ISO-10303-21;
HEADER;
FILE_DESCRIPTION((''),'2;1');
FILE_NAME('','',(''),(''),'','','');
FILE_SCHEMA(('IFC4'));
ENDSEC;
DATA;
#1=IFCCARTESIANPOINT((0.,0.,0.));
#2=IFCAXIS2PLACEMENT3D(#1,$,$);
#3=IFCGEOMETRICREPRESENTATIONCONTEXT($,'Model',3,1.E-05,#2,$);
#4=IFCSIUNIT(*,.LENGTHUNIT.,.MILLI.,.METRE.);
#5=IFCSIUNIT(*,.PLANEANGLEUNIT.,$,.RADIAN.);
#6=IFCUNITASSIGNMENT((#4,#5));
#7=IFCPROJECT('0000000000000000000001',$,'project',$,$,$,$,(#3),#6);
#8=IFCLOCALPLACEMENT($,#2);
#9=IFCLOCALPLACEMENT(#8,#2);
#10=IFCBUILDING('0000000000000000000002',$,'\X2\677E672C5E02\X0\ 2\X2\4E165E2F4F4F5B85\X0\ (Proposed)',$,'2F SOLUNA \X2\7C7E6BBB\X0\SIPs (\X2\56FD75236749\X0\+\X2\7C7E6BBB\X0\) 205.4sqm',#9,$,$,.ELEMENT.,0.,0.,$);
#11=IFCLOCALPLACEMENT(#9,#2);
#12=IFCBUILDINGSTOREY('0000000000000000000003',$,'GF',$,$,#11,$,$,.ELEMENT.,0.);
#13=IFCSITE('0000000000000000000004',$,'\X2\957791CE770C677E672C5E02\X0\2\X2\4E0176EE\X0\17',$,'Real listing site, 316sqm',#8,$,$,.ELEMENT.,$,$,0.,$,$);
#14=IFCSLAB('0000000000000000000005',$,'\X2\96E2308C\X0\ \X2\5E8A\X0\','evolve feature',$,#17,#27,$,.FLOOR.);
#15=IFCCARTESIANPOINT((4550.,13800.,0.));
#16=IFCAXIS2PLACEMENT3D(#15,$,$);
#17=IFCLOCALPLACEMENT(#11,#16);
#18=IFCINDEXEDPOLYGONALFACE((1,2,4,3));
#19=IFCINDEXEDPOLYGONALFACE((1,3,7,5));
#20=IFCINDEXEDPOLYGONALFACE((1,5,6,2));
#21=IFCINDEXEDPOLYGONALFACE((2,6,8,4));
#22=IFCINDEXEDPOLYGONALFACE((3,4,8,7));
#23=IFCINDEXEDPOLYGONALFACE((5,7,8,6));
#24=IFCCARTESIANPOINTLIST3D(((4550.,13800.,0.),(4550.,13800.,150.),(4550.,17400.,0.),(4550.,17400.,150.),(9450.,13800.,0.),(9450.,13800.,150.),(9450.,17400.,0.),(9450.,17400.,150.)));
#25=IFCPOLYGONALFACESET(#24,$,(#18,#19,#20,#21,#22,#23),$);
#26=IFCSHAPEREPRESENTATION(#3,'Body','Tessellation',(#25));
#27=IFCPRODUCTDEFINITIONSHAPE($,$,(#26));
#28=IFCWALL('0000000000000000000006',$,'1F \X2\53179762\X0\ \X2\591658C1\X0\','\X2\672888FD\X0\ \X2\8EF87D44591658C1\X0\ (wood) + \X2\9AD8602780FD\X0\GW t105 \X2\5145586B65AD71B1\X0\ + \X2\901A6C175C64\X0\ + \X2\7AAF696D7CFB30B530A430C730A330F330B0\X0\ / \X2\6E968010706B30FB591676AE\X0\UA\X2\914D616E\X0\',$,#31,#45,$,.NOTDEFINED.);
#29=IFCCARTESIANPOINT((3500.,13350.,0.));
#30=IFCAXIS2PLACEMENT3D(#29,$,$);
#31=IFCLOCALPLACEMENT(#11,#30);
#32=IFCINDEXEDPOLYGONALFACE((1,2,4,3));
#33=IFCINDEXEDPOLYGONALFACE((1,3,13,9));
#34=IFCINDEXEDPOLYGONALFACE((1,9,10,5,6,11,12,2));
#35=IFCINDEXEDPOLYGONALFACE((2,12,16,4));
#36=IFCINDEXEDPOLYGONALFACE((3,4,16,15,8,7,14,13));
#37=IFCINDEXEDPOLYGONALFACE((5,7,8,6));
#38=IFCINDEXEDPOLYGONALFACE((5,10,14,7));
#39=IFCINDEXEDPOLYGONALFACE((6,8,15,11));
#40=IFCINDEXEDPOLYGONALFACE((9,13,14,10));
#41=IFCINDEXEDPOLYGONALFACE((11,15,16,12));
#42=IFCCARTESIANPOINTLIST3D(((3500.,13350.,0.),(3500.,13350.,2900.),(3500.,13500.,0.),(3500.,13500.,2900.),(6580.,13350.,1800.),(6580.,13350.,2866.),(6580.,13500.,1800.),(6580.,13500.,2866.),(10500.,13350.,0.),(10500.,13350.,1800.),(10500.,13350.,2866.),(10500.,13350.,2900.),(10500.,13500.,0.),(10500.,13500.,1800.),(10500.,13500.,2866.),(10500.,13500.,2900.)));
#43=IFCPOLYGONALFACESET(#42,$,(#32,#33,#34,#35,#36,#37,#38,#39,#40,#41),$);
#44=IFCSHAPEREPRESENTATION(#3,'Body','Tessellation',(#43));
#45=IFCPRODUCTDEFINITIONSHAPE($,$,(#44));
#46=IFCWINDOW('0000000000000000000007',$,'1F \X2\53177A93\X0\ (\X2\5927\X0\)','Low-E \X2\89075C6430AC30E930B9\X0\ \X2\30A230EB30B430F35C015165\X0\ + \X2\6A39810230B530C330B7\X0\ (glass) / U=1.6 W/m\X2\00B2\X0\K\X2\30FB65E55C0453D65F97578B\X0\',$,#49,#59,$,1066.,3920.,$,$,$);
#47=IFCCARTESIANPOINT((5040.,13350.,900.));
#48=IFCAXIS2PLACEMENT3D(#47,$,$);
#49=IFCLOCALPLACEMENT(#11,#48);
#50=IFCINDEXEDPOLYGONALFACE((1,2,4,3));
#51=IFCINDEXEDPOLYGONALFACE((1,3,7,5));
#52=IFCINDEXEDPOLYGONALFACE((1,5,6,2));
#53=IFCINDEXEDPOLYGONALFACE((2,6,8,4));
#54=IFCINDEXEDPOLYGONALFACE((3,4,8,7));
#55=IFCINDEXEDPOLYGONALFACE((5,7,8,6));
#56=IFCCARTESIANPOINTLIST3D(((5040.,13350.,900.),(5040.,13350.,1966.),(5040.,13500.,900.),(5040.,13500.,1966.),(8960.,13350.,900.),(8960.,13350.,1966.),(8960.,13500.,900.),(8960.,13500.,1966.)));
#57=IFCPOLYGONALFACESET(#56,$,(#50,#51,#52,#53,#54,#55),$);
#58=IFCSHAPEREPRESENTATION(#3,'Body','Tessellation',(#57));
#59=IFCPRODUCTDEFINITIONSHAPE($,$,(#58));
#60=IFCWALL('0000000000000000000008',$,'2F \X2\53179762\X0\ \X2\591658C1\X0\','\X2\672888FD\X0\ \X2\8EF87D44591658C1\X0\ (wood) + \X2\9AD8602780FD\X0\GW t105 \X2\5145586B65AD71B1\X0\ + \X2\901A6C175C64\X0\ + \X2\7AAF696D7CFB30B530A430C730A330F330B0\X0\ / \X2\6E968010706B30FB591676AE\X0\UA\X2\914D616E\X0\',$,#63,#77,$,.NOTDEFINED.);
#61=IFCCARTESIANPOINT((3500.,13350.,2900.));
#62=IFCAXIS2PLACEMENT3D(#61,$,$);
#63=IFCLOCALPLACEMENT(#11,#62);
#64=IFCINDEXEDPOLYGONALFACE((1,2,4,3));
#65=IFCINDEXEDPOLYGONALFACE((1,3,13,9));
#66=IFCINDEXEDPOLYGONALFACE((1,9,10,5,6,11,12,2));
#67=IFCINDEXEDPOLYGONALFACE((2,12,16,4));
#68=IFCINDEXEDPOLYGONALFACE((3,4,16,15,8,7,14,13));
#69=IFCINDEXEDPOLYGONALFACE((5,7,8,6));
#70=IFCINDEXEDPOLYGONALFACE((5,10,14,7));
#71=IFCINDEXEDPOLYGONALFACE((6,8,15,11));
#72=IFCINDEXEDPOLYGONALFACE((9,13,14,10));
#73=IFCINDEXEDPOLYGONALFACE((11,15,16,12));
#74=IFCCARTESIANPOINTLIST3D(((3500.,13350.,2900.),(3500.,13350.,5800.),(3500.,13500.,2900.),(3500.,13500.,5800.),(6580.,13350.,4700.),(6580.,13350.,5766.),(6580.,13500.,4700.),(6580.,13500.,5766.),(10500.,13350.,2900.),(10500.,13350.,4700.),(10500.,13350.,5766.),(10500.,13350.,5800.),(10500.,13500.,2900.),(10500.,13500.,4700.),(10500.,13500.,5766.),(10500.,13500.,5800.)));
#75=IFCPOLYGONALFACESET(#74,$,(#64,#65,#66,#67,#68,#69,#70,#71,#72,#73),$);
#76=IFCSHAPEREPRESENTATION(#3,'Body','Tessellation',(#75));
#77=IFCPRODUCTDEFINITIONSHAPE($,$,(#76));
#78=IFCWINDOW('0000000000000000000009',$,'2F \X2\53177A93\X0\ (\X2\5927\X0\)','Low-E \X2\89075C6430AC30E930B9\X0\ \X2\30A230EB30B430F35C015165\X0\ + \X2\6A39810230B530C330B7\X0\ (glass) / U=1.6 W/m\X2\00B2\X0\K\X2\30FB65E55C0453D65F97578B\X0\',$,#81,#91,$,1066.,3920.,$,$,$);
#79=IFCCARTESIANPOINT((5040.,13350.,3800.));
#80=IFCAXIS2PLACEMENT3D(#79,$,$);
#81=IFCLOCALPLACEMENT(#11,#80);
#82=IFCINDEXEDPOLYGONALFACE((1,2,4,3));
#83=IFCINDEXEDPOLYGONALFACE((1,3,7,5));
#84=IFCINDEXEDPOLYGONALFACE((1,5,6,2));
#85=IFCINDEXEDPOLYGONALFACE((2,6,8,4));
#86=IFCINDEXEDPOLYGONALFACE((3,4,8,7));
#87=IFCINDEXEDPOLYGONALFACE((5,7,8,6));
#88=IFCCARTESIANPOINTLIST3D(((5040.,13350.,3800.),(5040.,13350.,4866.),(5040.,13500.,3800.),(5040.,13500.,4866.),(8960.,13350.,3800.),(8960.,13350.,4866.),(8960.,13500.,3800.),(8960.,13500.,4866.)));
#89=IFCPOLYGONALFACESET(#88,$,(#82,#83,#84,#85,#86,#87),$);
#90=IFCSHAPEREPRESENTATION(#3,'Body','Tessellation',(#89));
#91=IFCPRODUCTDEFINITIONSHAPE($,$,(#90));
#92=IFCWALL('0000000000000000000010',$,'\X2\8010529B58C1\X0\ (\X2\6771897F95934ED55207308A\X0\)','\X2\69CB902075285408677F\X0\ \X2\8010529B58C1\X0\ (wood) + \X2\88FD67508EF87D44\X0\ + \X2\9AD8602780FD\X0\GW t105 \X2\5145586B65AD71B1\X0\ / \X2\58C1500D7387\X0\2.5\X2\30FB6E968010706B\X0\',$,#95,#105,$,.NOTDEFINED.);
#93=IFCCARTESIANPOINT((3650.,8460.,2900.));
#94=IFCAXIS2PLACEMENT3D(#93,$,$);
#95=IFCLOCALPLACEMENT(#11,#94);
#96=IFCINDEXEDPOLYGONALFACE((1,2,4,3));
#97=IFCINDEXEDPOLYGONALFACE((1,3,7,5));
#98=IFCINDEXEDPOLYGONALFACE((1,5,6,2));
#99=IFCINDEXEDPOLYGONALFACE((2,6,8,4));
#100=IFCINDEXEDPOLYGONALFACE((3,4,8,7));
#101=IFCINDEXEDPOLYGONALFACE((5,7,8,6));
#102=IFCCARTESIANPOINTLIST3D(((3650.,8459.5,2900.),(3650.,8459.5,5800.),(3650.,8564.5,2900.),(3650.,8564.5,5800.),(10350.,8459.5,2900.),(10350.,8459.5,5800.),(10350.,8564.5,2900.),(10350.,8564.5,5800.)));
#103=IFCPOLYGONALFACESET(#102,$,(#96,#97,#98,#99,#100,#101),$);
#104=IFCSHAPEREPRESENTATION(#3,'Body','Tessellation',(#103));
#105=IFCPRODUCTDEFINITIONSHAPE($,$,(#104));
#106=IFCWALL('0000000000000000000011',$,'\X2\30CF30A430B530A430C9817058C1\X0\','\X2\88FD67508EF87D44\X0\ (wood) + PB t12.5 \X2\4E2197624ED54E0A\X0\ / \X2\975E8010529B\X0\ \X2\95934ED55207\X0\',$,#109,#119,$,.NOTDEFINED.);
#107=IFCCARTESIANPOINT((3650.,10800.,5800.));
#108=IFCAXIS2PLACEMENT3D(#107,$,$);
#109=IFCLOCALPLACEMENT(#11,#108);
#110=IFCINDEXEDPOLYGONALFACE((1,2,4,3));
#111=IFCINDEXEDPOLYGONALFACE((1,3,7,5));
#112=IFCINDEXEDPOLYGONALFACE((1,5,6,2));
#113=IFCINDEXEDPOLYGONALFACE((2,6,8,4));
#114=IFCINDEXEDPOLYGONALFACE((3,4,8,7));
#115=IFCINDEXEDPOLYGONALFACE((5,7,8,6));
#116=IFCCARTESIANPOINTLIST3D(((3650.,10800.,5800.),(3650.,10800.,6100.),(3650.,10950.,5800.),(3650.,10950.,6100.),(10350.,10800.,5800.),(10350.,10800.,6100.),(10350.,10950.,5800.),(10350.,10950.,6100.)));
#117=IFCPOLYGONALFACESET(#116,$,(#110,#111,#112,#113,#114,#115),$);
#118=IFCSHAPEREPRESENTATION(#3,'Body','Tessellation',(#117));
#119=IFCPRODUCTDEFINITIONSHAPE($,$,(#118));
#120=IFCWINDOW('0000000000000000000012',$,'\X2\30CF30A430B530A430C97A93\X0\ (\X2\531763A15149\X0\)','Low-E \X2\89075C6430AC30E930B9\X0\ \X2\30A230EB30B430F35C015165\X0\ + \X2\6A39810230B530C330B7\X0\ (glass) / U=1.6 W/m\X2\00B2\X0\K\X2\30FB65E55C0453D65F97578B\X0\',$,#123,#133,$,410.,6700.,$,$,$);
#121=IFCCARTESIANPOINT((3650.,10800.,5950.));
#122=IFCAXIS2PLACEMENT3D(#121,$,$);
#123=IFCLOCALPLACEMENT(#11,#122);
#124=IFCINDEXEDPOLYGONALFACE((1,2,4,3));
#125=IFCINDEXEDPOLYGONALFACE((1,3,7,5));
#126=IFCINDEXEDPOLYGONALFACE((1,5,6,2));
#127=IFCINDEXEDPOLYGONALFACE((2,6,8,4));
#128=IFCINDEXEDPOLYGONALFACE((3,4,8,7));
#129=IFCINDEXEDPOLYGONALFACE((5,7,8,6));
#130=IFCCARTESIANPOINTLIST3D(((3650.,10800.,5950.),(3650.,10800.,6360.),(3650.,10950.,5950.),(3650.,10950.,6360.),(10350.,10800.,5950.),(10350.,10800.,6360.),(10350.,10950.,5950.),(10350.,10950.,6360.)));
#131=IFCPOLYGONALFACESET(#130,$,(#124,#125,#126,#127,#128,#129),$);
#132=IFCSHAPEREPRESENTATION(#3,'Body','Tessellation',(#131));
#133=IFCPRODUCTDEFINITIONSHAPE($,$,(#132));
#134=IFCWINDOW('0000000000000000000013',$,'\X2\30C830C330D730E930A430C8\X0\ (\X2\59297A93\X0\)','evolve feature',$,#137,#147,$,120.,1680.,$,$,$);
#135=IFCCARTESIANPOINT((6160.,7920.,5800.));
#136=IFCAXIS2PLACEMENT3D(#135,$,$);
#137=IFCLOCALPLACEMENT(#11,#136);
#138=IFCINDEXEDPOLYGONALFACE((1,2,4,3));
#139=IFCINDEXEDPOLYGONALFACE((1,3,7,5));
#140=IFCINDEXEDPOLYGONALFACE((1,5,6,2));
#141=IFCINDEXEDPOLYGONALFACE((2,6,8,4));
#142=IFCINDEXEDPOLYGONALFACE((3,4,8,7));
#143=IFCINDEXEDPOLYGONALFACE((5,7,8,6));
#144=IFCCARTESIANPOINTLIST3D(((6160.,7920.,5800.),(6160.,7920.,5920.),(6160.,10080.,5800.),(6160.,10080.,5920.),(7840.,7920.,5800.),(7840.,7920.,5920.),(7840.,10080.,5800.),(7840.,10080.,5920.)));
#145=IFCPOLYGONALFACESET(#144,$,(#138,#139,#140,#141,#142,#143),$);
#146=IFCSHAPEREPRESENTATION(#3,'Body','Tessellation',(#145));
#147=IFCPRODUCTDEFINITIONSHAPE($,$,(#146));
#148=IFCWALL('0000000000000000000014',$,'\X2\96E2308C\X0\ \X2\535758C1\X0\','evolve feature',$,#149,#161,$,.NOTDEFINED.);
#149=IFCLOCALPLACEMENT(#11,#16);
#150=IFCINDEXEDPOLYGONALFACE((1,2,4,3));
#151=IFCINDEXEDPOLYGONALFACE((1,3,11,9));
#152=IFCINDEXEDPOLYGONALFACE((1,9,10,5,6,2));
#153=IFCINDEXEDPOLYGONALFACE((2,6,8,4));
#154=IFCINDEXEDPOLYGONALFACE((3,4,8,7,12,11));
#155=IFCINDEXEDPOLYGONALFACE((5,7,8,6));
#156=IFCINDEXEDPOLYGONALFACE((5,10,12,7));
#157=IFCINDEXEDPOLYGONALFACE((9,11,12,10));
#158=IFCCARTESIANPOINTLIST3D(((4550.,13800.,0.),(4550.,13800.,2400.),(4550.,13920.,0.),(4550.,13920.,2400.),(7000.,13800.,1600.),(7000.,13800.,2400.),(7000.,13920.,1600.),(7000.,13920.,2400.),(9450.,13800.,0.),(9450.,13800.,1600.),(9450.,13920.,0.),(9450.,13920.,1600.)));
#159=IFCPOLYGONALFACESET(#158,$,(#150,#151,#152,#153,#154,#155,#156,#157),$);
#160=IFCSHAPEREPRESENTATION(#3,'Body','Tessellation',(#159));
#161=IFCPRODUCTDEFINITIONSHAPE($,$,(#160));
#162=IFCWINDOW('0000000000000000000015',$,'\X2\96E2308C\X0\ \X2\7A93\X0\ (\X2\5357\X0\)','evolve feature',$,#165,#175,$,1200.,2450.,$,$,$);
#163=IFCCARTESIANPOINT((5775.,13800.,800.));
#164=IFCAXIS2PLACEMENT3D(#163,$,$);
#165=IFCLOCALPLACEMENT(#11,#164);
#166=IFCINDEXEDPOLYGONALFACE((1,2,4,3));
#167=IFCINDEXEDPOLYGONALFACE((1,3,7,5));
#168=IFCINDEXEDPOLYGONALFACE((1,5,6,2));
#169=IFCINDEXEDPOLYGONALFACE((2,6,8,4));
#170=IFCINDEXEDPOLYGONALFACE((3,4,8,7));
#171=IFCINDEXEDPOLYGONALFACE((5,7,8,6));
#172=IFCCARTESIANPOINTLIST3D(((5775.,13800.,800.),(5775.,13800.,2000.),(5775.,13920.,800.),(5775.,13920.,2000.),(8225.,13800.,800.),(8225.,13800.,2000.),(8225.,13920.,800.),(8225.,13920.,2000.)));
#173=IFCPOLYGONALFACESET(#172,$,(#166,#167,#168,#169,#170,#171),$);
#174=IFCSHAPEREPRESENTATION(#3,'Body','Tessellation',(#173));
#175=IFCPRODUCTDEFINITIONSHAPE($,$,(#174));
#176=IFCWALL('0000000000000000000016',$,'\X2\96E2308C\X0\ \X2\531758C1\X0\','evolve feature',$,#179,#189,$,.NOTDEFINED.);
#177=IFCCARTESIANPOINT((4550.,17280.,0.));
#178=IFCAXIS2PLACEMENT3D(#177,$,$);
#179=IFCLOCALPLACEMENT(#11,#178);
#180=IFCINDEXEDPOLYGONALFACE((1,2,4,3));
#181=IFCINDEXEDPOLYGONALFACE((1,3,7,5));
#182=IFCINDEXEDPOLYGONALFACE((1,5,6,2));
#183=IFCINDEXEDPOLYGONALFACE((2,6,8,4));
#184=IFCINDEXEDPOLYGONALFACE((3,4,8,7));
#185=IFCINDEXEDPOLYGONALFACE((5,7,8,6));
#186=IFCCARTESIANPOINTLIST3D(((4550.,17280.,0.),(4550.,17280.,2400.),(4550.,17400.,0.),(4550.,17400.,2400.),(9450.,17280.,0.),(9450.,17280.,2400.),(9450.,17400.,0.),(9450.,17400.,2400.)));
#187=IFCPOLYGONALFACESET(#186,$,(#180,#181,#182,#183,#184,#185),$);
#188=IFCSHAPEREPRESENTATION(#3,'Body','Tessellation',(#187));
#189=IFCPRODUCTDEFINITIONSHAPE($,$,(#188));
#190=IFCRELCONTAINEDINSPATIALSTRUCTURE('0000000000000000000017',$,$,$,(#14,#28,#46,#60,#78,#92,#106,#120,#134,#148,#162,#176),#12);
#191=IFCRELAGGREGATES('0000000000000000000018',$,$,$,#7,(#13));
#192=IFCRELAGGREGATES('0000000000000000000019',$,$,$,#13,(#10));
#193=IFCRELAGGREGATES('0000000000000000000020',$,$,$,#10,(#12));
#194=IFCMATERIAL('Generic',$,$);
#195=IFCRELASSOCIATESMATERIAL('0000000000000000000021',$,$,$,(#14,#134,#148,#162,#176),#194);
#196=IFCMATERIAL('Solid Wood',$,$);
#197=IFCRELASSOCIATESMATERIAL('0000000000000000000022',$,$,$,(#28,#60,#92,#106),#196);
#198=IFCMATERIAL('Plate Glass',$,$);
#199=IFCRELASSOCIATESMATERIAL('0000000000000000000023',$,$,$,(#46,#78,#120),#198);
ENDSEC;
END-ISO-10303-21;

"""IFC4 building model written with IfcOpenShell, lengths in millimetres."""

from ifc_helpers import new_model, si_unit, frame, frame_2d, origin, place, context, project, spatial, rectangle, extrude, material, element, fill, save


model = new_model("IFC4")

# Units and contexts
model_context = context("Model", 3, precision=1e-05, world=origin())
ifc_project = project(units=[si_unit("LENGTHUNIT", "METRE", prefix="MILLI"), si_unit("PLANEANGLEUNIT", "RADIAN")], contexts=[model_context])

# Site, building, storey
site_placement = place(None, origin())
site = spatial("IfcSite", under=ifc_project, at=site_placement, Name="長野県松本市2丁目17", ObjectType="Real listing site, 316sqm", CompositionType="ELEMENT", RefElevation=0.0)
building_placement = place(site_placement, origin())
building = spatial("IfcBuilding", under=site, at=building_placement, Name="松本市 2世帯住宅 (Proposed)", ObjectType="2F SOLUNA 籾殻SIPs (国産杉+籾殻) 205.4sqm", CompositionType="ELEMENT", ElevationOfRefHeight=0.0, ElevationOfTerrain=0.0)
storey_placement = place(building_placement, origin())
storey = spatial("IfcBuildingStorey", under=building, at=storey_placement, Name="GF", CompositionType="ELEMENT", Elevation=0.0)

# Slab
ifc_material_1 = material(Name="Generic")
slab_placement = place(storey_placement, frame((4550.0, 13800.0, 0.0)))
element("IfcSlab", 1, at=slab_placement, inside=storey, material=ifc_material_1, Name="離れ 床", Description="evolve feature", PredefinedType="FLOOR", context=model_context, shape_type="SweptSolid", body=[
    extrude(rectangle(XDim=4900.0, YDim=3600.0, at=frame_2d((2450.0, 1800.0))), frame((4550.0, 13800.0, 0.0)), (0.0, 0.0, 1.0), 150.0),
])

# Wall, opening, window
ifc_material_2 = material(Name="Solid Wood")
wall_1_placement = place(storey_placement, frame((3500.0, 13350.0, 0.0)))
wall_1 = element("IfcWall", 2, at=wall_1_placement, inside=storey, material=ifc_material_2, Name="1F 北面 外壁", Description="木製 軸組外壁 (wood) + 高性能GW t105 充填断熱 + 通気層 + 窯業系サイディング / 準耐火・外皮UA配慮", PredefinedType="NOTDEFINED", context=model_context, shape_type="SweptSolid", body=[
    extrude(rectangle(XDim=7000.0, YDim=150.0, at=frame_2d((3500.0, 75.0))), frame((3500.0, 13350.0, 0.0)), (0.0, 0.0, 1.0), 2900.0),
])
opening_1_placement = place(storey_placement, frame((5040.0, 13350.0, 900.0)))
opening_1 = element("IfcOpeningElement", 3, at=opening_1_placement, cuts=wall_1, PredefinedType="NOTDEFINED", context=model_context, shape_type="SweptSolid", body=[
    extrude(rectangle(XDim=3920.0, YDim=150.0, at=frame_2d((1960.0, 75.0))), frame((5040.0, 13350.0, 900.0)), (0.0, 0.0, 1.0), 1066.0),
])
ifc_material_3 = material(Name="Plate Glass")
window_1_placement = place(storey_placement, frame((5040.0, 13350.0, 900.0)))
window_1 = element("IfcWindow", 4, at=window_1_placement, inside=storey, material=ifc_material_3, Name="1F 北窓 (大)", Description="Low-E 複層ガラス アルゴン封入 + 樹脂サッシ (glass) / U=1.6 W/m²K・日射取得型", OverallHeight=1066.0, OverallWidth=3920.0, context=model_context, shape_type="SweptSolid", body=[
    extrude(rectangle(XDim=3920.0, YDim=150.0, at=frame_2d((1960.0, 75.0))), frame((5040.0, 13350.0, 900.0)), (0.0, 0.0, 1.0), 1066.0),
])
fill(opening_1, window_1)

# Wall, opening, window
wall_2_placement = place(storey_placement, frame((3500.0, 13350.0, 2900.0)))
wall_2 = element("IfcWall", 5, at=wall_2_placement, inside=storey, material=ifc_material_2, Name="2F 北面 外壁", Description="木製 軸組外壁 (wood) + 高性能GW t105 充填断熱 + 通気層 + 窯業系サイディング / 準耐火・外皮UA配慮", PredefinedType="NOTDEFINED", context=model_context, shape_type="SweptSolid", body=[
    extrude(rectangle(XDim=7000.0, YDim=150.0, at=frame_2d((3500.0, 75.0))), frame((3500.0, 13350.0, 2900.0)), (0.0, 0.0, 1.0), 2900.0),
])
opening_2_placement = place(storey_placement, frame((5040.0, 13350.0, 3800.0)))
opening_2 = element("IfcOpeningElement", 6, at=opening_2_placement, cuts=wall_2, PredefinedType="NOTDEFINED", context=model_context, shape_type="SweptSolid", body=[
    extrude(rectangle(XDim=3920.0, YDim=150.0, at=frame_2d((1960.0, 75.0))), frame((5040.0, 13350.0, 3800.0)), (0.0, 0.0, 1.0), 1066.0),
])
window_2_placement = place(storey_placement, frame((5040.0, 13350.0, 3800.0)))
window_2 = element("IfcWindow", 7, at=window_2_placement, inside=storey, material=ifc_material_3, Name="2F 北窓 (大)", Description="Low-E 複層ガラス アルゴン封入 + 樹脂サッシ (glass) / U=1.6 W/m²K・日射取得型", OverallHeight=1066.0, OverallWidth=3920.0, context=model_context, shape_type="SweptSolid", body=[
    extrude(rectangle(XDim=3920.0, YDim=150.0, at=frame_2d((1960.0, 75.0))), frame((5040.0, 13350.0, 3800.0)), (0.0, 0.0, 1.0), 1066.0),
])
fill(opening_2, window_2)

# Wall
wall_3_placement = place(storey_placement, frame((3650.0, 8460.0, 2900.0)))
element("IfcWall", 8, at=wall_3_placement, inside=storey, material=ifc_material_2, Name="耐力壁 (東西間仕切り)", Description="構造用合板 耐力壁 (wood) + 製材軸組 + 高性能GW t105 充填断熱 / 壁倍率2.5・準耐火", PredefinedType="NOTDEFINED", context=model_context, shape_type="SweptSolid", body=[
    extrude(rectangle(XDim=6700.0, YDim=105.0, at=frame_2d((3350.0, 52.0))), frame((3650.0, 8460.0, 2900.0)), (0.0, 0.0, 1.0), 2900.0),
])

# Wall, opening, window
wall_4_placement = place(storey_placement, frame((3650.0, 10800.0, 5800.0)))
wall_4 = element("IfcWall", 9, at=wall_4_placement, inside=storey, material=ifc_material_2, Name="ハイサイド腰壁", Description="製材軸組 (wood) + PB t12.5 両面仕上 / 非耐力 間仕切", PredefinedType="NOTDEFINED", context=model_context, shape_type="SweptSolid", body=[
    extrude(rectangle(XDim=6700.0, YDim=150.0, at=frame_2d((3350.0, 75.0))), frame((3650.0, 10800.0, 5800.0)), (0.0, 0.0, 1.0), 700.0),
])
opening_3_placement = place(storey_placement, frame((3650.0, 10800.0, 5950.0)))
opening_3 = element("IfcOpeningElement", 10, at=opening_3_placement, cuts=wall_4, PredefinedType="NOTDEFINED", context=model_context, shape_type="SweptSolid", body=[
    extrude(rectangle(XDim=6700.0, YDim=150.0, at=frame_2d((3350.0, 75.0))), frame((3650.0, 10800.0, 5950.0)), (0.0, 0.0, 1.0), 410.0),
])
window_3_placement = place(storey_placement, frame((3650.0, 10800.0, 5950.0)))
window_3 = element("IfcWindow", 11, at=window_3_placement, inside=storey, material=ifc_material_3, Name="ハイサイド窓 (北採光)", Description="Low-E 複層ガラス アルゴン封入 + 樹脂サッシ (glass) / U=1.6 W/m²K・日射取得型", OverallHeight=410.0, OverallWidth=6700.0, context=model_context, shape_type="SweptSolid", body=[
    extrude(rectangle(XDim=6700.0, YDim=150.0, at=frame_2d((3350.0, 75.0))), frame((3650.0, 10800.0, 5950.0)), (0.0, 0.0, 1.0), 410.0),
])
fill(opening_3, window_3)

# Window
window_4_placement = place(storey_placement, frame((6160.0, 7920.0, 5800.0)))
element("IfcWindow", 12, at=window_4_placement, inside=storey, material=ifc_material_1, Name="トップライト (天窓)", Description="evolve feature", OverallHeight=120.0, OverallWidth=1680.0, context=model_context, shape_type="SweptSolid", body=[
    extrude(rectangle(XDim=1680.0, YDim=2160.0, at=frame_2d((840.0, 1080.0))), frame((6160.0, 7920.0, 5800.0)), (0.0, 0.0, 1.0), 120.0),
])

# Wall, opening, window
wall_5_placement = place(storey_placement, frame((4550.0, 13800.0, 0.0)))
wall_5 = element("IfcWall", 13, at=wall_5_placement, inside=storey, material=ifc_material_1, Name="離れ 南壁", Description="evolve feature", PredefinedType="NOTDEFINED", context=model_context, shape_type="SweptSolid", body=[
    extrude(rectangle(XDim=4900.0, YDim=120.0, at=frame_2d((2450.0, 60.0))), frame((4550.0, 13800.0, 0.0)), (0.0, 0.0, 1.0), 2400.0),
])
opening_4_placement = place(storey_placement, frame((5775.0, 13800.0, 800.0)))
opening_4 = element("IfcOpeningElement", 14, at=opening_4_placement, cuts=wall_5, PredefinedType="NOTDEFINED", context=model_context, shape_type="SweptSolid", body=[
    extrude(rectangle(XDim=2450.0, YDim=120.0, at=frame_2d((1225.0, 60.0))), frame((5775.0, 13800.0, 800.0)), (0.0, 0.0, 1.0), 1200.0),
])
window_5_placement = place(storey_placement, frame((5775.0, 13800.0, 800.0)))
window_5 = element("IfcWindow", 15, at=window_5_placement, inside=storey, material=ifc_material_1, Name="離れ 窓 (南)", Description="evolve feature", OverallHeight=1200.0, OverallWidth=2450.0, context=model_context, shape_type="SweptSolid", body=[
    extrude(rectangle(XDim=2450.0, YDim=120.0, at=frame_2d((1225.0, 60.0))), frame((5775.0, 13800.0, 800.0)), (0.0, 0.0, 1.0), 1200.0),
])
fill(opening_4, window_5)

# Wall
wall_6_placement = place(storey_placement, frame((4550.0, 17280.0, 0.0)))
element("IfcWall", 16, at=wall_6_placement, inside=storey, material=ifc_material_1, Name="離れ 北壁", Description="evolve feature", PredefinedType="NOTDEFINED", context=model_context, shape_type="SweptSolid", body=[
    extrude(rectangle(XDim=4900.0, YDim=120.0, at=frame_2d((2450.0, 60.0))), frame((4550.0, 17280.0, 0.0)), (0.0, 0.0, 1.0), 2400.0),
])

save(model, "model.ifc")
